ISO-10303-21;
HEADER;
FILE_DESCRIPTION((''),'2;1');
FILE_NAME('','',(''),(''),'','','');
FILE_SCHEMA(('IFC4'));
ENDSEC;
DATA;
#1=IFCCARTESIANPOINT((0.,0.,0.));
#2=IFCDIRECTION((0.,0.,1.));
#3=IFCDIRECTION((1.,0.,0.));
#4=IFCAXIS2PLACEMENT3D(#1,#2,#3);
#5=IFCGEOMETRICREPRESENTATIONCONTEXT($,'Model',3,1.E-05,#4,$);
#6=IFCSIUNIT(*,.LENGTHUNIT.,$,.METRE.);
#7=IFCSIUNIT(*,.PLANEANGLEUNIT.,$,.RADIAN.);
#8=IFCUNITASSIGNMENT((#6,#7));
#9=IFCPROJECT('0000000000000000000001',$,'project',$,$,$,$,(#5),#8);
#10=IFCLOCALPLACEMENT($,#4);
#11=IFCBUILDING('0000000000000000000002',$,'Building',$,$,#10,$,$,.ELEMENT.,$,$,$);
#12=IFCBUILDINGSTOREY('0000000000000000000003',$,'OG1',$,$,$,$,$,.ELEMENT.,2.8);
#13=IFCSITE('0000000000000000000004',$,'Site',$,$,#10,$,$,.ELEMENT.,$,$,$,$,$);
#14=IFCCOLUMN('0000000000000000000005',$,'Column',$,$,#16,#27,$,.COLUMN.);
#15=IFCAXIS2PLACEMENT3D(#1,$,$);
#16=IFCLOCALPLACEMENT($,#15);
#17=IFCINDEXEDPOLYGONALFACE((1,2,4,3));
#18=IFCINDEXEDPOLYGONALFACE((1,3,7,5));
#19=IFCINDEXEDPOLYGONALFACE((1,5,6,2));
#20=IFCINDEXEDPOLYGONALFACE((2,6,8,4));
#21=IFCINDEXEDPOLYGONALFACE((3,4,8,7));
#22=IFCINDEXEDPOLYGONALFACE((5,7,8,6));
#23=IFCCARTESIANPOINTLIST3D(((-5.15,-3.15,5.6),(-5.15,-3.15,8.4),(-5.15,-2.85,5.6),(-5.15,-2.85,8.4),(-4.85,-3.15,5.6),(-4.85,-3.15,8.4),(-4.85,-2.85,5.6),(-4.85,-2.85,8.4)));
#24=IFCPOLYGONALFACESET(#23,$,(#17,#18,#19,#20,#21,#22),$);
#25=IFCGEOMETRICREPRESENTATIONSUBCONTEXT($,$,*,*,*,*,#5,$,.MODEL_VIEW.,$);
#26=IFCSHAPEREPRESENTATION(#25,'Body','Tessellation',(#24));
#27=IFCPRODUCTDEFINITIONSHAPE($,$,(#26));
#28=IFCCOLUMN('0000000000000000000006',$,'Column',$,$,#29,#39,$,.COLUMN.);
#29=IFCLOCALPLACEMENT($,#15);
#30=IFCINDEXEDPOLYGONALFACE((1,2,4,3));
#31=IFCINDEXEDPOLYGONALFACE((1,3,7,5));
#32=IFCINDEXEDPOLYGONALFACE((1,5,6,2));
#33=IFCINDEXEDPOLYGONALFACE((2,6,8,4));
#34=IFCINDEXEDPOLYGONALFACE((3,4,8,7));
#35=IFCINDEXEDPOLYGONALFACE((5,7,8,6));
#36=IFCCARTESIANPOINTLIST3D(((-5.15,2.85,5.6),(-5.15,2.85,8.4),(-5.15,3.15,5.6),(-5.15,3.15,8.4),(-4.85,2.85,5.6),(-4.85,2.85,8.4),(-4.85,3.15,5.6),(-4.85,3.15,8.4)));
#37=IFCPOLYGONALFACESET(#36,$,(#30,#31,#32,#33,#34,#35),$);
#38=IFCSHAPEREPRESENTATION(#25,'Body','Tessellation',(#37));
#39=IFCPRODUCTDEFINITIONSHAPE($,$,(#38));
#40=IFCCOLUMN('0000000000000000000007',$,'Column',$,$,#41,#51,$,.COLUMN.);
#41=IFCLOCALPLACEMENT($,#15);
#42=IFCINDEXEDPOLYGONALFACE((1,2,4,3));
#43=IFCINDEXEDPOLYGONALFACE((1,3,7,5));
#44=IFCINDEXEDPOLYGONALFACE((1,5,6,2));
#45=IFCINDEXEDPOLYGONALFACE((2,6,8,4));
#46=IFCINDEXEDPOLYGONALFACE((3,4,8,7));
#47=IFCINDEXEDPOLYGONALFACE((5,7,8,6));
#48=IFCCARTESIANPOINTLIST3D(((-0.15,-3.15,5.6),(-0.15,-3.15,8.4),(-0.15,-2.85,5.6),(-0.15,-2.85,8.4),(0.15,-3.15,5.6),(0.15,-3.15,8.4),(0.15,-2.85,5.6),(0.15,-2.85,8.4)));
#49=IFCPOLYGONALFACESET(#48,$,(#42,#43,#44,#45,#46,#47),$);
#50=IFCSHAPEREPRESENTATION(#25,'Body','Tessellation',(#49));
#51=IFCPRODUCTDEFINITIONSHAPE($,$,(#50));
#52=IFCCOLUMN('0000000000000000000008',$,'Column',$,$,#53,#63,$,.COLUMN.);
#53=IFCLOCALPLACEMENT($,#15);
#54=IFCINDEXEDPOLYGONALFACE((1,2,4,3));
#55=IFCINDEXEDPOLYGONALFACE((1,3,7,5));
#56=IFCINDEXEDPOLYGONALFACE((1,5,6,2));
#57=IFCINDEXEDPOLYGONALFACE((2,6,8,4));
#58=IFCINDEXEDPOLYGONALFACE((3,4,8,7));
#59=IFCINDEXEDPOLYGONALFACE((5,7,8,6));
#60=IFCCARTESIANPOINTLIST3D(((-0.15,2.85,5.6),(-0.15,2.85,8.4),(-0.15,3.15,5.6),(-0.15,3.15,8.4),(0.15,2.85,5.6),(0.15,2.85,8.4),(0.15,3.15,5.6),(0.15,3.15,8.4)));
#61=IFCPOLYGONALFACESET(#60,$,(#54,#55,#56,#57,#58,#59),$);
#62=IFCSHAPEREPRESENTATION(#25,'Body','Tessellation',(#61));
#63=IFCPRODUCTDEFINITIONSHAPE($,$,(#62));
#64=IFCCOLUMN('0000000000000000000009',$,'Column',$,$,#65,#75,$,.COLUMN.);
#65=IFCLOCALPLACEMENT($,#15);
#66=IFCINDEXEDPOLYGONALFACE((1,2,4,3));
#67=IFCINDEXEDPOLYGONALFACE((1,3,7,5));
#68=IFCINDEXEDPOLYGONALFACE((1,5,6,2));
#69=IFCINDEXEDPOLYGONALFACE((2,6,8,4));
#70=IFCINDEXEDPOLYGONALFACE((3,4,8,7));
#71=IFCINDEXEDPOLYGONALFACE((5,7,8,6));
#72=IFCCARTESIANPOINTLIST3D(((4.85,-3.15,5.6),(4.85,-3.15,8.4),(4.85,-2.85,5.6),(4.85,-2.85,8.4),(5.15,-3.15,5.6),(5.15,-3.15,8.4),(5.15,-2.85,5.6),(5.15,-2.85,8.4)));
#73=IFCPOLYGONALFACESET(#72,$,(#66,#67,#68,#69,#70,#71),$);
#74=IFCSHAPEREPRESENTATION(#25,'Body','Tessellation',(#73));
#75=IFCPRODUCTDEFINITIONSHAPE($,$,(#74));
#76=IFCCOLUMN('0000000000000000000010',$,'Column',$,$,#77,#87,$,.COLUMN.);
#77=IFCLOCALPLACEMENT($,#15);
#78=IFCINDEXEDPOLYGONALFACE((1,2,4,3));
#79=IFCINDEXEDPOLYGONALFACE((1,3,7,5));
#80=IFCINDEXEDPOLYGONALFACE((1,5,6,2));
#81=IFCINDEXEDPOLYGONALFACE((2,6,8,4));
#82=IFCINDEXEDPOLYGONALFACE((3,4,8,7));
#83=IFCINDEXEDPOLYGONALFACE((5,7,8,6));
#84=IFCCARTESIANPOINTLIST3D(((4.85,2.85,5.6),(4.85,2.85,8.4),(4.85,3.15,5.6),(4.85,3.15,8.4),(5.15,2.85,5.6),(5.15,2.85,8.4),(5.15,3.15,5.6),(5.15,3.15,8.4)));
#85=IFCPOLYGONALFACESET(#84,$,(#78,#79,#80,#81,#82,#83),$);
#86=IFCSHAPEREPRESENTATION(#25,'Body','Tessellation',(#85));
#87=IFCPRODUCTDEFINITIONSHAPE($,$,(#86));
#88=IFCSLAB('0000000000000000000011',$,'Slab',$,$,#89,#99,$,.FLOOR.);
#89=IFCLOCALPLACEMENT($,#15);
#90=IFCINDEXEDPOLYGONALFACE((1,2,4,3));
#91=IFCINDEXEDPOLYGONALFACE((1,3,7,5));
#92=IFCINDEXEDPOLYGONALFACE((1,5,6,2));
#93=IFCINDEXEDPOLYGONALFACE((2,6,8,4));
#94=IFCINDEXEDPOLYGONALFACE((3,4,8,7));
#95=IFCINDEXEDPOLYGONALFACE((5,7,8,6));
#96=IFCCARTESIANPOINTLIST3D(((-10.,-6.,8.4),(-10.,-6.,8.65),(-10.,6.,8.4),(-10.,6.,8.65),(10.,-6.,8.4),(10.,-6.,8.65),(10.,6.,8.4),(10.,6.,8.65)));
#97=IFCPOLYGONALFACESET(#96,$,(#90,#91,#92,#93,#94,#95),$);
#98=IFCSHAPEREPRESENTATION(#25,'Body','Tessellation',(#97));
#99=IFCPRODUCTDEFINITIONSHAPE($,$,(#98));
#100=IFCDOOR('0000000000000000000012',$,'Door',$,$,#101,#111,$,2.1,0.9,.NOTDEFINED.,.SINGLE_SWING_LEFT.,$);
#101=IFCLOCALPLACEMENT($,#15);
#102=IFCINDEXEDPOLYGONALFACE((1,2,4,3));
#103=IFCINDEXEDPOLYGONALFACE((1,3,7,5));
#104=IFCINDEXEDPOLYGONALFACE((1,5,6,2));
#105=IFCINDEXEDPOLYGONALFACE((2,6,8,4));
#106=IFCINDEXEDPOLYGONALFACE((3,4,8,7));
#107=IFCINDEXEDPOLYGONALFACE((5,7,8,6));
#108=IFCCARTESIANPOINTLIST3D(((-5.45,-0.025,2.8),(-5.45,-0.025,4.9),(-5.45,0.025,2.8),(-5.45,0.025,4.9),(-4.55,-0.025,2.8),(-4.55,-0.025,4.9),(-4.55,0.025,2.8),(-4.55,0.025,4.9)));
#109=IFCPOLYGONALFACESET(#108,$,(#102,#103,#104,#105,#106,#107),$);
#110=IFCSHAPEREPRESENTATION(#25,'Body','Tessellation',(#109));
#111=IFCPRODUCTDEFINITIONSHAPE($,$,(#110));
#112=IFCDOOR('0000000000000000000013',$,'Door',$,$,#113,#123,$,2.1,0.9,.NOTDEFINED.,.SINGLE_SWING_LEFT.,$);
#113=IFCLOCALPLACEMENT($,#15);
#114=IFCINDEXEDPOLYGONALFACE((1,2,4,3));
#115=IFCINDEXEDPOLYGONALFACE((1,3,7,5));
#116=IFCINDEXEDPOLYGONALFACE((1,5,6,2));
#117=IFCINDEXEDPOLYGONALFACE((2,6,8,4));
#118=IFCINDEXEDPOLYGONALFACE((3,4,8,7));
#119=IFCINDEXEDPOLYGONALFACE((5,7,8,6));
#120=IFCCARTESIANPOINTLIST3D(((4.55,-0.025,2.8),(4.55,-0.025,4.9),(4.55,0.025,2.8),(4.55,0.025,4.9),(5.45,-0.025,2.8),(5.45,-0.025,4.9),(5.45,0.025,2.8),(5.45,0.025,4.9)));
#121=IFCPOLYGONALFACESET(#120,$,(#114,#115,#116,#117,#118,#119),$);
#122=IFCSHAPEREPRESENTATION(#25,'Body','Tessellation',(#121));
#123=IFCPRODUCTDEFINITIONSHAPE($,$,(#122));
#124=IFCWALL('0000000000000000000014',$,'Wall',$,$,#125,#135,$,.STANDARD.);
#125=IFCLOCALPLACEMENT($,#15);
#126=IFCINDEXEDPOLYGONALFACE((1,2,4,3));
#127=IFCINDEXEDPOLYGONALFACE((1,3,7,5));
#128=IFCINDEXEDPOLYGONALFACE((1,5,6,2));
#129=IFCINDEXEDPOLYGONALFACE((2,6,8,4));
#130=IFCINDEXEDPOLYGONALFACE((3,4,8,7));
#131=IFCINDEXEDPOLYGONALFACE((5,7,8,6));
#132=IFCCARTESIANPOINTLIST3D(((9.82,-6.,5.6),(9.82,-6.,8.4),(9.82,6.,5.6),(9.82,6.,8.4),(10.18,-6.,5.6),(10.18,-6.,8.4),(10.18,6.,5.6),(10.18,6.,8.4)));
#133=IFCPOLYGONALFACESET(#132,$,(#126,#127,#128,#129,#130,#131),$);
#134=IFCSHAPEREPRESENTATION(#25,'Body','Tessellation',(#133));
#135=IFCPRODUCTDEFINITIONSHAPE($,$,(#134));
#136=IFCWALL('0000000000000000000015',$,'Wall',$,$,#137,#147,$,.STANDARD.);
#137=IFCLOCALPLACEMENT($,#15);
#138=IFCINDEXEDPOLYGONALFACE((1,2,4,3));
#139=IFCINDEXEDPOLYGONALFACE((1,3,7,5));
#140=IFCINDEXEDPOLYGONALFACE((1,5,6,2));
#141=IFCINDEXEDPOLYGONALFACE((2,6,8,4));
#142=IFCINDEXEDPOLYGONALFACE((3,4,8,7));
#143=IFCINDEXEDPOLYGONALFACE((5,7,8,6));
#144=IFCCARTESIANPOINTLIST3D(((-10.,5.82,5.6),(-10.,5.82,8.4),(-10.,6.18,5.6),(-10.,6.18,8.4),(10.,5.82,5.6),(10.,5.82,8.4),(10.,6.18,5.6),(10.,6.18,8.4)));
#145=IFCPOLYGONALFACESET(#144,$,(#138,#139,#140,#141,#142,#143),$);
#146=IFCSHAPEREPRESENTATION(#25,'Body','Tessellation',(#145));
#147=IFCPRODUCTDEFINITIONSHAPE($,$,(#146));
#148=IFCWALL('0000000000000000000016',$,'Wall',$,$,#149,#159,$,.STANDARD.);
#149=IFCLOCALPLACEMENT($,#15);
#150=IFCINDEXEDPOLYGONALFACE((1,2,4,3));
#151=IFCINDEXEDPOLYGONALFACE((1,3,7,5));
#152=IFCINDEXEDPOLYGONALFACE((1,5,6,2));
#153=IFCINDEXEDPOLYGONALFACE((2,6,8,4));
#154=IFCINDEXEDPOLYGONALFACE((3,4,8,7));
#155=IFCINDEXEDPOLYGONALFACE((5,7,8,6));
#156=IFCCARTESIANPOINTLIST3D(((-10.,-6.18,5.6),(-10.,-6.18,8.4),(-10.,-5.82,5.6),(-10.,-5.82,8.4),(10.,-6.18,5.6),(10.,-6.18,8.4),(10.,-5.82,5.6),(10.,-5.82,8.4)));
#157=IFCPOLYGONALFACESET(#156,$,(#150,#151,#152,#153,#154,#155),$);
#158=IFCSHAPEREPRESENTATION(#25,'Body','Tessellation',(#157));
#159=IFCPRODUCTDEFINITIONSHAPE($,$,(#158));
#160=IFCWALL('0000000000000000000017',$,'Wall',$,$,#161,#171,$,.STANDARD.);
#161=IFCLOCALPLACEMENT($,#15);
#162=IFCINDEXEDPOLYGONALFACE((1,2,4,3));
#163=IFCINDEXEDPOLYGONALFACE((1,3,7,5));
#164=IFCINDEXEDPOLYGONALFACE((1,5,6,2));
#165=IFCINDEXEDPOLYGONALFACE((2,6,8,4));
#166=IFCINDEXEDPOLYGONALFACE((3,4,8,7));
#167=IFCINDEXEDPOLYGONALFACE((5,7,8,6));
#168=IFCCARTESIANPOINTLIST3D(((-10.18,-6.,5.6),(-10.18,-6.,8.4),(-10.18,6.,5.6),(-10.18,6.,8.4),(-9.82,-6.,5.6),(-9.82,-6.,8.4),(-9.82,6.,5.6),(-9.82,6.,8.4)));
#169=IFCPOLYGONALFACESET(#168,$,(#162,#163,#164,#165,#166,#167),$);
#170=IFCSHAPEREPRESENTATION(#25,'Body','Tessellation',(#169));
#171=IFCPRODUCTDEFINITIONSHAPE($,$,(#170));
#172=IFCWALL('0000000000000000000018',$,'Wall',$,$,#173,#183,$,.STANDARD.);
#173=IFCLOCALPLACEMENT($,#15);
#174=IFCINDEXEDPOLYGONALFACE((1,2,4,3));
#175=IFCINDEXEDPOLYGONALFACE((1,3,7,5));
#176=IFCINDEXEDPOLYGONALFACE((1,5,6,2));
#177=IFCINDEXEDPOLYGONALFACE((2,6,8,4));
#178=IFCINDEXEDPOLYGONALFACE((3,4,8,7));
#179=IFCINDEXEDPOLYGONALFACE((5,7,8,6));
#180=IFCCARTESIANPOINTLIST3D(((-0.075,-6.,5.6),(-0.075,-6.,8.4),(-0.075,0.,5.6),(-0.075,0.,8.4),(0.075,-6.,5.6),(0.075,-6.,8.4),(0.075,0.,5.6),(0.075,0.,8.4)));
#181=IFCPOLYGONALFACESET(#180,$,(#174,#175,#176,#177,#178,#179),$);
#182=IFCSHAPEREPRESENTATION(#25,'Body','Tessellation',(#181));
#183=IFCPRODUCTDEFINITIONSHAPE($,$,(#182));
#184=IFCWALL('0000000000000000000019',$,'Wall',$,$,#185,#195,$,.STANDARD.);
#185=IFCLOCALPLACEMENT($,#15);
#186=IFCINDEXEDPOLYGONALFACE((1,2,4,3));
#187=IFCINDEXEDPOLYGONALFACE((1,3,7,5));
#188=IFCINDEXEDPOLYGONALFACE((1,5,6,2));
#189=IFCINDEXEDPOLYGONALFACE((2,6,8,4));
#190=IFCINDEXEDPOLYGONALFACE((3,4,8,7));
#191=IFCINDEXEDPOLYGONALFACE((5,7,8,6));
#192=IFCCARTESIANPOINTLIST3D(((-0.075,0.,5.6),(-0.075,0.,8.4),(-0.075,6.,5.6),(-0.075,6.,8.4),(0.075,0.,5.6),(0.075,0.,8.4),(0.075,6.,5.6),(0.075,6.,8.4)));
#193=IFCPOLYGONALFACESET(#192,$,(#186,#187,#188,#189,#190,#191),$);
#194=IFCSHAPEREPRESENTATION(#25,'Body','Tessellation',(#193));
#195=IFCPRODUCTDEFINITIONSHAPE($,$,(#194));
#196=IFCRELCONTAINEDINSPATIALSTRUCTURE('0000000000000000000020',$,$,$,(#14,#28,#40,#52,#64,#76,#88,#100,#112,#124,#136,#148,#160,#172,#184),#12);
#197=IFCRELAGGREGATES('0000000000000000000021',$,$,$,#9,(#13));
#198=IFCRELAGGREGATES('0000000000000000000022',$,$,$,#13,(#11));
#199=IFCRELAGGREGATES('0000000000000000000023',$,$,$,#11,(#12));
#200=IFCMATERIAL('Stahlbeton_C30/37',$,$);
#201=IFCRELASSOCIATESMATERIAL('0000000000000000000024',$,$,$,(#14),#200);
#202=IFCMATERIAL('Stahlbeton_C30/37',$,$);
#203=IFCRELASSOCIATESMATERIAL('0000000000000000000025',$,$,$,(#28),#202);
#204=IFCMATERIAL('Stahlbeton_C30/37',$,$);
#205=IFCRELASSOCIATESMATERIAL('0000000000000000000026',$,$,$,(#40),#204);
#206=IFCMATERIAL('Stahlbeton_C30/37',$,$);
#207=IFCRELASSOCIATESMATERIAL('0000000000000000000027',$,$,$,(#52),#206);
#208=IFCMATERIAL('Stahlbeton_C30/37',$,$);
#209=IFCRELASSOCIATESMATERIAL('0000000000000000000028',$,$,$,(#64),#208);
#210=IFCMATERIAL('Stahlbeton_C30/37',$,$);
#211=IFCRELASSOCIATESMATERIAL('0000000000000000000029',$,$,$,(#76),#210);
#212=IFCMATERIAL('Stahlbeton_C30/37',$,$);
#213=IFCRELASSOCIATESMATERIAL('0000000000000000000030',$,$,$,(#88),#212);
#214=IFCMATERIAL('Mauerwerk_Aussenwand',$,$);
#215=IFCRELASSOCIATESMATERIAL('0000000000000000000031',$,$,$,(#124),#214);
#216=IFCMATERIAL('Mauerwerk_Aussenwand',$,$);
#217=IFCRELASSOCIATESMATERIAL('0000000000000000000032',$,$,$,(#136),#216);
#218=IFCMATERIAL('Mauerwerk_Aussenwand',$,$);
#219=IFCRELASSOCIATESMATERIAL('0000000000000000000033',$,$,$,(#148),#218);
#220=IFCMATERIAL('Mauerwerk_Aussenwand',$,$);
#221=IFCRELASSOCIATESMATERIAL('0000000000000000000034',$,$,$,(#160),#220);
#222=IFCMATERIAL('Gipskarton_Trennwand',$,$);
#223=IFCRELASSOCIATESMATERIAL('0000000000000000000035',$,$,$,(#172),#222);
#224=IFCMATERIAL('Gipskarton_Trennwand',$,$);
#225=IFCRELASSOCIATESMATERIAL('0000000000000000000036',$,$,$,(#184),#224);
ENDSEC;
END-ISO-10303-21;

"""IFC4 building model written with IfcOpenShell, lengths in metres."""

from ifc_helpers import new_model, si_unit, frame, frame_2d, origin, origin_with_axes, origin_2d, place, context, subcontext, project, spatial, rectangle, extrude, material, element, save


model = new_model("IFC4")

# Units and contexts
model_context = context("Model", 3, precision=1e-05, world=origin_with_axes())
sub_context = subcontext(model_context, None, None, "MODEL_VIEW")
ifc_project = project(units=[si_unit("LENGTHUNIT", "METRE"), si_unit("PLANEANGLEUNIT", "RADIAN")], contexts=[model_context])

# Site, building, storey
placement_1 = place(None, origin_with_axes())
site = spatial("IfcSite", under=ifc_project, at=placement_1, Name="Site", CompositionType="ELEMENT")
building = spatial("IfcBuilding", under=site, at=placement_1, Name="Building", CompositionType="ELEMENT")
storey = spatial("IfcBuildingStorey", under=building, Name="OG1", CompositionType="ELEMENT", Elevation=2.8)

# Columns
ifc_material_1 = material(Name="Stahlbeton_C30/37")
placement_2 = place(None, origin_with_axes())
placement_3 = place(placement_2, frame((0.0, 0.0, 2.8)))
column_1_placement = place(placement_3, frame((-5.0, -3.0, 2.8)))
element("IfcColumn", 1, at=column_1_placement, inside=storey, material=ifc_material_1, Name="Column", PredefinedType="COLUMN", context=sub_context, shape_type="SweptSolid", body=[
    extrude(rectangle(XDim=0.3, YDim=0.3, at=origin_2d()), origin(), (0.0, 0.0, 1.0), 2.8),
])
ifc_material_2 = material(Name="Stahlbeton_C30/37")
placement_4 = place(None, origin_with_axes())
placement_5 = place(placement_4, frame((0.0, 0.0, 2.8)))
column_2_placement = place(placement_5, frame((-5.0, 3.0, 2.8)))
element("IfcColumn", 2, at=column_2_placement, inside=storey, material=ifc_material_2, Name="Column", PredefinedType="COLUMN", context=sub_context, shape_type="SweptSolid", body=[
    extrude(rectangle(XDim=0.3, YDim=0.3, at=origin_2d()), origin(), (0.0, 0.0, 1.0), 2.8),
])
ifc_material_3 = material(Name="Stahlbeton_C30/37")
placement_6 = place(None, origin_with_axes())
placement_7 = place(placement_6, frame((0.0, 0.0, 2.8)))
column_3_placement = place(placement_7, frame((0.0, -3.0, 2.8)))
element("IfcColumn", 3, at=column_3_placement, inside=storey, material=ifc_material_3, Name="Column", PredefinedType="COLUMN", context=sub_context, shape_type="SweptSolid", body=[
    extrude(rectangle(XDim=0.3, YDim=0.3, at=origin_2d()), origin(), (0.0, 0.0, 1.0), 2.8),
])
ifc_material_4 = material(Name="Stahlbeton_C30/37")
placement_8 = place(None, origin_with_axes())
placement_9 = place(placement_8, frame((0.0, 0.0, 2.8)))
column_4_placement = place(placement_9, frame((0.0, 3.0, 2.8)))
element("IfcColumn", 4, at=column_4_placement, inside=storey, material=ifc_material_4, Name="Column", PredefinedType="COLUMN", context=sub_context, shape_type="SweptSolid", body=[
    extrude(rectangle(XDim=0.3, YDim=0.3, at=origin_2d()), origin(), (0.0, 0.0, 1.0), 2.8),
])
ifc_material_5 = material(Name="Stahlbeton_C30/37")
placement_10 = place(None, origin_with_axes())
placement_11 = place(placement_10, frame((0.0, 0.0, 2.8)))
column_5_placement = place(placement_11, frame((5.0, -3.0, 2.8)))
element("IfcColumn", 5, at=column_5_placement, inside=storey, material=ifc_material_5, Name="Column", PredefinedType="COLUMN", context=sub_context, shape_type="SweptSolid", body=[
    extrude(rectangle(XDim=0.3, YDim=0.3, at=origin_2d()), origin(), (0.0, 0.0, 1.0), 2.8),
])
ifc_material_6 = material(Name="Stahlbeton_C30/37")
placement_12 = place(None, origin_with_axes())
placement_13 = place(placement_12, frame((0.0, 0.0, 2.8)))
column_6_placement = place(placement_13, frame((5.0, 3.0, 2.8)))
element("IfcColumn", 6, at=column_6_placement, inside=storey, material=ifc_material_6, Name="Column", PredefinedType="COLUMN", context=sub_context, shape_type="SweptSolid", body=[
    extrude(rectangle(XDim=0.3, YDim=0.3, at=origin_2d()), origin(), (0.0, 0.0, 1.0), 2.8),
])

# Slab
ifc_material_7 = material(Name="Stahlbeton_C30/37")
placement_14 = place(None, origin_with_axes())
placement_15 = place(placement_14, frame((0.0, 0.0, 2.8)))
slab_placement = place(placement_15, frame((-10.0, -6.0, 5.6)))
element("IfcSlab", 7, at=slab_placement, inside=storey, material=ifc_material_7, Name="Slab", PredefinedType="FLOOR", context=sub_context, shape_type="SweptSolid", body=[
    extrude(rectangle(XDim=20.0, YDim=12.0, at=frame_2d((10.0, 6.0))), origin(), (0.0, 0.0, 1.0), 0.25),
])

# Doors
placement_16 = place(None, origin_with_axes())
door_1_placement = place(placement_16, frame((-5.0, 0.0, 2.8)))
element("IfcDoor", 8, at=door_1_placement, inside=storey, Name="Door", OperationType="SINGLE_SWING_LEFT", OverallHeight=2.1, OverallWidth=0.9, PredefinedType="NOTDEFINED", context=sub_context, shape_type="SweptSolid", body=[
    extrude(rectangle(XDim=0.9, YDim=0.05, at=origin_2d()), origin(), (0.0, 0.0, 1.0), 2.1),
])
placement_17 = place(None, origin_with_axes())
door_2_placement = place(placement_17, frame((5.0, 0.0, 2.8)))
element("IfcDoor", 9, at=door_2_placement, inside=storey, Name="Door", OperationType="SINGLE_SWING_LEFT", OverallHeight=2.1, OverallWidth=0.9, PredefinedType="NOTDEFINED", context=sub_context, shape_type="SweptSolid", body=[
    extrude(rectangle(XDim=0.9, YDim=0.05, at=origin_2d()), origin(), (0.0, 0.0, 1.0), 2.1),
])

# Walls
ifc_material_8 = material(Name="Mauerwerk_Aussenwand")
placement_18 = place(None, origin_with_axes())
placement_19 = place(placement_18, frame((0.0, 0.0, 2.8)))
wall_1_placement = place(placement_19, frame((10.0, -6.0, 2.8), x_axis=(0.0, 1.0, 0.0)))
element("IfcWall", 10, at=wall_1_placement, inside=storey, material=ifc_material_8, Name="Wall", PredefinedType="STANDARD", context=sub_context, shape_type="SweptSolid", body=[
    extrude(rectangle(XDim=12.0, YDim=0.36, at=frame_2d((6.0, 0.0))), origin(), (0.0, 0.0, 1.0), 2.8),
])
ifc_material_9 = material(Name="Mauerwerk_Aussenwand")
placement_20 = place(None, origin_with_axes())
placement_21 = place(placement_20, frame((0.0, 0.0, 2.8)))
wall_2_placement = place(placement_21, frame((-10.0, 6.0, 2.8), x_axis=(1.0, 0.0, 0.0)))
element("IfcWall", 11, at=wall_2_placement, inside=storey, material=ifc_material_9, Name="Wall", PredefinedType="STANDARD", context=sub_context, shape_type="SweptSolid", body=[
    extrude(rectangle(XDim=20.0, YDim=0.36, at=frame_2d((10.0, 0.0))), origin(), (0.0, 0.0, 1.0), 2.8),
])
ifc_material_10 = material(Name="Mauerwerk_Aussenwand")
placement_22 = place(None, origin_with_axes())
placement_23 = place(placement_22, frame((0.0, 0.0, 2.8)))
wall_3_placement = place(placement_23, frame((-10.0, -6.0, 2.8), x_axis=(1.0, 0.0, 0.0)))
element("IfcWall", 12, at=wall_3_placement, inside=storey, material=ifc_material_10, Name="Wall", PredefinedType="STANDARD", context=sub_context, shape_type="SweptSolid", body=[
    extrude(rectangle(XDim=20.0, YDim=0.36, at=frame_2d((10.0, 0.0))), origin(), (0.0, 0.0, 1.0), 2.8),
])
ifc_material_11 = material(Name="Mauerwerk_Aussenwand")
placement_24 = place(None, origin_with_axes())
placement_25 = place(placement_24, frame((0.0, 0.0, 2.8)))
wall_4_placement = place(placement_25, frame((-10.0, -6.0, 2.8), x_axis=(0.0, 1.0, 0.0)))
element("IfcWall", 13, at=wall_4_placement, inside=storey, material=ifc_material_11, Name="Wall", PredefinedType="STANDARD", context=sub_context, shape_type="SweptSolid", body=[
    extrude(rectangle(XDim=12.0, YDim=0.36, at=frame_2d((6.0, 0.0))), origin(), (0.0, 0.0, 1.0), 2.8),
])
ifc_material_12 = material(Name="Gipskarton_Trennwand")
placement_26 = place(None, origin_with_axes())
placement_27 = place(placement_26, frame((0.0, 0.0, 2.8)))
wall_5_placement = place(placement_27, frame((0.0, -6.0, 2.8), x_axis=(0.0, 1.0, 0.0)))
element("IfcWall", 14, at=wall_5_placement, inside=storey, material=ifc_material_12, Name="Wall", PredefinedType="STANDARD", context=sub_context, shape_type="SweptSolid", body=[
    extrude(rectangle(XDim=6.0, YDim=0.15, at=frame_2d((3.0, 0.0))), origin(), (0.0, 0.0, 1.0), 2.8),
])
ifc_material_13 = material(Name="Gipskarton_Trennwand")
placement_28 = place(None, origin_with_axes())
placement_29 = place(placement_28, frame((0.0, 0.0, 2.8)))
wall_6_placement = place(placement_29, frame((0.0, 0.0, 2.8), x_axis=(0.0, 1.0, 0.0)))
element("IfcWall", 15, at=wall_6_placement, inside=storey, material=ifc_material_13, Name="Wall", PredefinedType="STANDARD", context=sub_context, shape_type="SweptSolid", body=[
    extrude(rectangle(XDim=6.0, YDim=0.15, at=frame_2d((3.0, 0.0))), origin(), (0.0, 0.0, 1.0), 2.8),
])

save(model, "model.ifc")
